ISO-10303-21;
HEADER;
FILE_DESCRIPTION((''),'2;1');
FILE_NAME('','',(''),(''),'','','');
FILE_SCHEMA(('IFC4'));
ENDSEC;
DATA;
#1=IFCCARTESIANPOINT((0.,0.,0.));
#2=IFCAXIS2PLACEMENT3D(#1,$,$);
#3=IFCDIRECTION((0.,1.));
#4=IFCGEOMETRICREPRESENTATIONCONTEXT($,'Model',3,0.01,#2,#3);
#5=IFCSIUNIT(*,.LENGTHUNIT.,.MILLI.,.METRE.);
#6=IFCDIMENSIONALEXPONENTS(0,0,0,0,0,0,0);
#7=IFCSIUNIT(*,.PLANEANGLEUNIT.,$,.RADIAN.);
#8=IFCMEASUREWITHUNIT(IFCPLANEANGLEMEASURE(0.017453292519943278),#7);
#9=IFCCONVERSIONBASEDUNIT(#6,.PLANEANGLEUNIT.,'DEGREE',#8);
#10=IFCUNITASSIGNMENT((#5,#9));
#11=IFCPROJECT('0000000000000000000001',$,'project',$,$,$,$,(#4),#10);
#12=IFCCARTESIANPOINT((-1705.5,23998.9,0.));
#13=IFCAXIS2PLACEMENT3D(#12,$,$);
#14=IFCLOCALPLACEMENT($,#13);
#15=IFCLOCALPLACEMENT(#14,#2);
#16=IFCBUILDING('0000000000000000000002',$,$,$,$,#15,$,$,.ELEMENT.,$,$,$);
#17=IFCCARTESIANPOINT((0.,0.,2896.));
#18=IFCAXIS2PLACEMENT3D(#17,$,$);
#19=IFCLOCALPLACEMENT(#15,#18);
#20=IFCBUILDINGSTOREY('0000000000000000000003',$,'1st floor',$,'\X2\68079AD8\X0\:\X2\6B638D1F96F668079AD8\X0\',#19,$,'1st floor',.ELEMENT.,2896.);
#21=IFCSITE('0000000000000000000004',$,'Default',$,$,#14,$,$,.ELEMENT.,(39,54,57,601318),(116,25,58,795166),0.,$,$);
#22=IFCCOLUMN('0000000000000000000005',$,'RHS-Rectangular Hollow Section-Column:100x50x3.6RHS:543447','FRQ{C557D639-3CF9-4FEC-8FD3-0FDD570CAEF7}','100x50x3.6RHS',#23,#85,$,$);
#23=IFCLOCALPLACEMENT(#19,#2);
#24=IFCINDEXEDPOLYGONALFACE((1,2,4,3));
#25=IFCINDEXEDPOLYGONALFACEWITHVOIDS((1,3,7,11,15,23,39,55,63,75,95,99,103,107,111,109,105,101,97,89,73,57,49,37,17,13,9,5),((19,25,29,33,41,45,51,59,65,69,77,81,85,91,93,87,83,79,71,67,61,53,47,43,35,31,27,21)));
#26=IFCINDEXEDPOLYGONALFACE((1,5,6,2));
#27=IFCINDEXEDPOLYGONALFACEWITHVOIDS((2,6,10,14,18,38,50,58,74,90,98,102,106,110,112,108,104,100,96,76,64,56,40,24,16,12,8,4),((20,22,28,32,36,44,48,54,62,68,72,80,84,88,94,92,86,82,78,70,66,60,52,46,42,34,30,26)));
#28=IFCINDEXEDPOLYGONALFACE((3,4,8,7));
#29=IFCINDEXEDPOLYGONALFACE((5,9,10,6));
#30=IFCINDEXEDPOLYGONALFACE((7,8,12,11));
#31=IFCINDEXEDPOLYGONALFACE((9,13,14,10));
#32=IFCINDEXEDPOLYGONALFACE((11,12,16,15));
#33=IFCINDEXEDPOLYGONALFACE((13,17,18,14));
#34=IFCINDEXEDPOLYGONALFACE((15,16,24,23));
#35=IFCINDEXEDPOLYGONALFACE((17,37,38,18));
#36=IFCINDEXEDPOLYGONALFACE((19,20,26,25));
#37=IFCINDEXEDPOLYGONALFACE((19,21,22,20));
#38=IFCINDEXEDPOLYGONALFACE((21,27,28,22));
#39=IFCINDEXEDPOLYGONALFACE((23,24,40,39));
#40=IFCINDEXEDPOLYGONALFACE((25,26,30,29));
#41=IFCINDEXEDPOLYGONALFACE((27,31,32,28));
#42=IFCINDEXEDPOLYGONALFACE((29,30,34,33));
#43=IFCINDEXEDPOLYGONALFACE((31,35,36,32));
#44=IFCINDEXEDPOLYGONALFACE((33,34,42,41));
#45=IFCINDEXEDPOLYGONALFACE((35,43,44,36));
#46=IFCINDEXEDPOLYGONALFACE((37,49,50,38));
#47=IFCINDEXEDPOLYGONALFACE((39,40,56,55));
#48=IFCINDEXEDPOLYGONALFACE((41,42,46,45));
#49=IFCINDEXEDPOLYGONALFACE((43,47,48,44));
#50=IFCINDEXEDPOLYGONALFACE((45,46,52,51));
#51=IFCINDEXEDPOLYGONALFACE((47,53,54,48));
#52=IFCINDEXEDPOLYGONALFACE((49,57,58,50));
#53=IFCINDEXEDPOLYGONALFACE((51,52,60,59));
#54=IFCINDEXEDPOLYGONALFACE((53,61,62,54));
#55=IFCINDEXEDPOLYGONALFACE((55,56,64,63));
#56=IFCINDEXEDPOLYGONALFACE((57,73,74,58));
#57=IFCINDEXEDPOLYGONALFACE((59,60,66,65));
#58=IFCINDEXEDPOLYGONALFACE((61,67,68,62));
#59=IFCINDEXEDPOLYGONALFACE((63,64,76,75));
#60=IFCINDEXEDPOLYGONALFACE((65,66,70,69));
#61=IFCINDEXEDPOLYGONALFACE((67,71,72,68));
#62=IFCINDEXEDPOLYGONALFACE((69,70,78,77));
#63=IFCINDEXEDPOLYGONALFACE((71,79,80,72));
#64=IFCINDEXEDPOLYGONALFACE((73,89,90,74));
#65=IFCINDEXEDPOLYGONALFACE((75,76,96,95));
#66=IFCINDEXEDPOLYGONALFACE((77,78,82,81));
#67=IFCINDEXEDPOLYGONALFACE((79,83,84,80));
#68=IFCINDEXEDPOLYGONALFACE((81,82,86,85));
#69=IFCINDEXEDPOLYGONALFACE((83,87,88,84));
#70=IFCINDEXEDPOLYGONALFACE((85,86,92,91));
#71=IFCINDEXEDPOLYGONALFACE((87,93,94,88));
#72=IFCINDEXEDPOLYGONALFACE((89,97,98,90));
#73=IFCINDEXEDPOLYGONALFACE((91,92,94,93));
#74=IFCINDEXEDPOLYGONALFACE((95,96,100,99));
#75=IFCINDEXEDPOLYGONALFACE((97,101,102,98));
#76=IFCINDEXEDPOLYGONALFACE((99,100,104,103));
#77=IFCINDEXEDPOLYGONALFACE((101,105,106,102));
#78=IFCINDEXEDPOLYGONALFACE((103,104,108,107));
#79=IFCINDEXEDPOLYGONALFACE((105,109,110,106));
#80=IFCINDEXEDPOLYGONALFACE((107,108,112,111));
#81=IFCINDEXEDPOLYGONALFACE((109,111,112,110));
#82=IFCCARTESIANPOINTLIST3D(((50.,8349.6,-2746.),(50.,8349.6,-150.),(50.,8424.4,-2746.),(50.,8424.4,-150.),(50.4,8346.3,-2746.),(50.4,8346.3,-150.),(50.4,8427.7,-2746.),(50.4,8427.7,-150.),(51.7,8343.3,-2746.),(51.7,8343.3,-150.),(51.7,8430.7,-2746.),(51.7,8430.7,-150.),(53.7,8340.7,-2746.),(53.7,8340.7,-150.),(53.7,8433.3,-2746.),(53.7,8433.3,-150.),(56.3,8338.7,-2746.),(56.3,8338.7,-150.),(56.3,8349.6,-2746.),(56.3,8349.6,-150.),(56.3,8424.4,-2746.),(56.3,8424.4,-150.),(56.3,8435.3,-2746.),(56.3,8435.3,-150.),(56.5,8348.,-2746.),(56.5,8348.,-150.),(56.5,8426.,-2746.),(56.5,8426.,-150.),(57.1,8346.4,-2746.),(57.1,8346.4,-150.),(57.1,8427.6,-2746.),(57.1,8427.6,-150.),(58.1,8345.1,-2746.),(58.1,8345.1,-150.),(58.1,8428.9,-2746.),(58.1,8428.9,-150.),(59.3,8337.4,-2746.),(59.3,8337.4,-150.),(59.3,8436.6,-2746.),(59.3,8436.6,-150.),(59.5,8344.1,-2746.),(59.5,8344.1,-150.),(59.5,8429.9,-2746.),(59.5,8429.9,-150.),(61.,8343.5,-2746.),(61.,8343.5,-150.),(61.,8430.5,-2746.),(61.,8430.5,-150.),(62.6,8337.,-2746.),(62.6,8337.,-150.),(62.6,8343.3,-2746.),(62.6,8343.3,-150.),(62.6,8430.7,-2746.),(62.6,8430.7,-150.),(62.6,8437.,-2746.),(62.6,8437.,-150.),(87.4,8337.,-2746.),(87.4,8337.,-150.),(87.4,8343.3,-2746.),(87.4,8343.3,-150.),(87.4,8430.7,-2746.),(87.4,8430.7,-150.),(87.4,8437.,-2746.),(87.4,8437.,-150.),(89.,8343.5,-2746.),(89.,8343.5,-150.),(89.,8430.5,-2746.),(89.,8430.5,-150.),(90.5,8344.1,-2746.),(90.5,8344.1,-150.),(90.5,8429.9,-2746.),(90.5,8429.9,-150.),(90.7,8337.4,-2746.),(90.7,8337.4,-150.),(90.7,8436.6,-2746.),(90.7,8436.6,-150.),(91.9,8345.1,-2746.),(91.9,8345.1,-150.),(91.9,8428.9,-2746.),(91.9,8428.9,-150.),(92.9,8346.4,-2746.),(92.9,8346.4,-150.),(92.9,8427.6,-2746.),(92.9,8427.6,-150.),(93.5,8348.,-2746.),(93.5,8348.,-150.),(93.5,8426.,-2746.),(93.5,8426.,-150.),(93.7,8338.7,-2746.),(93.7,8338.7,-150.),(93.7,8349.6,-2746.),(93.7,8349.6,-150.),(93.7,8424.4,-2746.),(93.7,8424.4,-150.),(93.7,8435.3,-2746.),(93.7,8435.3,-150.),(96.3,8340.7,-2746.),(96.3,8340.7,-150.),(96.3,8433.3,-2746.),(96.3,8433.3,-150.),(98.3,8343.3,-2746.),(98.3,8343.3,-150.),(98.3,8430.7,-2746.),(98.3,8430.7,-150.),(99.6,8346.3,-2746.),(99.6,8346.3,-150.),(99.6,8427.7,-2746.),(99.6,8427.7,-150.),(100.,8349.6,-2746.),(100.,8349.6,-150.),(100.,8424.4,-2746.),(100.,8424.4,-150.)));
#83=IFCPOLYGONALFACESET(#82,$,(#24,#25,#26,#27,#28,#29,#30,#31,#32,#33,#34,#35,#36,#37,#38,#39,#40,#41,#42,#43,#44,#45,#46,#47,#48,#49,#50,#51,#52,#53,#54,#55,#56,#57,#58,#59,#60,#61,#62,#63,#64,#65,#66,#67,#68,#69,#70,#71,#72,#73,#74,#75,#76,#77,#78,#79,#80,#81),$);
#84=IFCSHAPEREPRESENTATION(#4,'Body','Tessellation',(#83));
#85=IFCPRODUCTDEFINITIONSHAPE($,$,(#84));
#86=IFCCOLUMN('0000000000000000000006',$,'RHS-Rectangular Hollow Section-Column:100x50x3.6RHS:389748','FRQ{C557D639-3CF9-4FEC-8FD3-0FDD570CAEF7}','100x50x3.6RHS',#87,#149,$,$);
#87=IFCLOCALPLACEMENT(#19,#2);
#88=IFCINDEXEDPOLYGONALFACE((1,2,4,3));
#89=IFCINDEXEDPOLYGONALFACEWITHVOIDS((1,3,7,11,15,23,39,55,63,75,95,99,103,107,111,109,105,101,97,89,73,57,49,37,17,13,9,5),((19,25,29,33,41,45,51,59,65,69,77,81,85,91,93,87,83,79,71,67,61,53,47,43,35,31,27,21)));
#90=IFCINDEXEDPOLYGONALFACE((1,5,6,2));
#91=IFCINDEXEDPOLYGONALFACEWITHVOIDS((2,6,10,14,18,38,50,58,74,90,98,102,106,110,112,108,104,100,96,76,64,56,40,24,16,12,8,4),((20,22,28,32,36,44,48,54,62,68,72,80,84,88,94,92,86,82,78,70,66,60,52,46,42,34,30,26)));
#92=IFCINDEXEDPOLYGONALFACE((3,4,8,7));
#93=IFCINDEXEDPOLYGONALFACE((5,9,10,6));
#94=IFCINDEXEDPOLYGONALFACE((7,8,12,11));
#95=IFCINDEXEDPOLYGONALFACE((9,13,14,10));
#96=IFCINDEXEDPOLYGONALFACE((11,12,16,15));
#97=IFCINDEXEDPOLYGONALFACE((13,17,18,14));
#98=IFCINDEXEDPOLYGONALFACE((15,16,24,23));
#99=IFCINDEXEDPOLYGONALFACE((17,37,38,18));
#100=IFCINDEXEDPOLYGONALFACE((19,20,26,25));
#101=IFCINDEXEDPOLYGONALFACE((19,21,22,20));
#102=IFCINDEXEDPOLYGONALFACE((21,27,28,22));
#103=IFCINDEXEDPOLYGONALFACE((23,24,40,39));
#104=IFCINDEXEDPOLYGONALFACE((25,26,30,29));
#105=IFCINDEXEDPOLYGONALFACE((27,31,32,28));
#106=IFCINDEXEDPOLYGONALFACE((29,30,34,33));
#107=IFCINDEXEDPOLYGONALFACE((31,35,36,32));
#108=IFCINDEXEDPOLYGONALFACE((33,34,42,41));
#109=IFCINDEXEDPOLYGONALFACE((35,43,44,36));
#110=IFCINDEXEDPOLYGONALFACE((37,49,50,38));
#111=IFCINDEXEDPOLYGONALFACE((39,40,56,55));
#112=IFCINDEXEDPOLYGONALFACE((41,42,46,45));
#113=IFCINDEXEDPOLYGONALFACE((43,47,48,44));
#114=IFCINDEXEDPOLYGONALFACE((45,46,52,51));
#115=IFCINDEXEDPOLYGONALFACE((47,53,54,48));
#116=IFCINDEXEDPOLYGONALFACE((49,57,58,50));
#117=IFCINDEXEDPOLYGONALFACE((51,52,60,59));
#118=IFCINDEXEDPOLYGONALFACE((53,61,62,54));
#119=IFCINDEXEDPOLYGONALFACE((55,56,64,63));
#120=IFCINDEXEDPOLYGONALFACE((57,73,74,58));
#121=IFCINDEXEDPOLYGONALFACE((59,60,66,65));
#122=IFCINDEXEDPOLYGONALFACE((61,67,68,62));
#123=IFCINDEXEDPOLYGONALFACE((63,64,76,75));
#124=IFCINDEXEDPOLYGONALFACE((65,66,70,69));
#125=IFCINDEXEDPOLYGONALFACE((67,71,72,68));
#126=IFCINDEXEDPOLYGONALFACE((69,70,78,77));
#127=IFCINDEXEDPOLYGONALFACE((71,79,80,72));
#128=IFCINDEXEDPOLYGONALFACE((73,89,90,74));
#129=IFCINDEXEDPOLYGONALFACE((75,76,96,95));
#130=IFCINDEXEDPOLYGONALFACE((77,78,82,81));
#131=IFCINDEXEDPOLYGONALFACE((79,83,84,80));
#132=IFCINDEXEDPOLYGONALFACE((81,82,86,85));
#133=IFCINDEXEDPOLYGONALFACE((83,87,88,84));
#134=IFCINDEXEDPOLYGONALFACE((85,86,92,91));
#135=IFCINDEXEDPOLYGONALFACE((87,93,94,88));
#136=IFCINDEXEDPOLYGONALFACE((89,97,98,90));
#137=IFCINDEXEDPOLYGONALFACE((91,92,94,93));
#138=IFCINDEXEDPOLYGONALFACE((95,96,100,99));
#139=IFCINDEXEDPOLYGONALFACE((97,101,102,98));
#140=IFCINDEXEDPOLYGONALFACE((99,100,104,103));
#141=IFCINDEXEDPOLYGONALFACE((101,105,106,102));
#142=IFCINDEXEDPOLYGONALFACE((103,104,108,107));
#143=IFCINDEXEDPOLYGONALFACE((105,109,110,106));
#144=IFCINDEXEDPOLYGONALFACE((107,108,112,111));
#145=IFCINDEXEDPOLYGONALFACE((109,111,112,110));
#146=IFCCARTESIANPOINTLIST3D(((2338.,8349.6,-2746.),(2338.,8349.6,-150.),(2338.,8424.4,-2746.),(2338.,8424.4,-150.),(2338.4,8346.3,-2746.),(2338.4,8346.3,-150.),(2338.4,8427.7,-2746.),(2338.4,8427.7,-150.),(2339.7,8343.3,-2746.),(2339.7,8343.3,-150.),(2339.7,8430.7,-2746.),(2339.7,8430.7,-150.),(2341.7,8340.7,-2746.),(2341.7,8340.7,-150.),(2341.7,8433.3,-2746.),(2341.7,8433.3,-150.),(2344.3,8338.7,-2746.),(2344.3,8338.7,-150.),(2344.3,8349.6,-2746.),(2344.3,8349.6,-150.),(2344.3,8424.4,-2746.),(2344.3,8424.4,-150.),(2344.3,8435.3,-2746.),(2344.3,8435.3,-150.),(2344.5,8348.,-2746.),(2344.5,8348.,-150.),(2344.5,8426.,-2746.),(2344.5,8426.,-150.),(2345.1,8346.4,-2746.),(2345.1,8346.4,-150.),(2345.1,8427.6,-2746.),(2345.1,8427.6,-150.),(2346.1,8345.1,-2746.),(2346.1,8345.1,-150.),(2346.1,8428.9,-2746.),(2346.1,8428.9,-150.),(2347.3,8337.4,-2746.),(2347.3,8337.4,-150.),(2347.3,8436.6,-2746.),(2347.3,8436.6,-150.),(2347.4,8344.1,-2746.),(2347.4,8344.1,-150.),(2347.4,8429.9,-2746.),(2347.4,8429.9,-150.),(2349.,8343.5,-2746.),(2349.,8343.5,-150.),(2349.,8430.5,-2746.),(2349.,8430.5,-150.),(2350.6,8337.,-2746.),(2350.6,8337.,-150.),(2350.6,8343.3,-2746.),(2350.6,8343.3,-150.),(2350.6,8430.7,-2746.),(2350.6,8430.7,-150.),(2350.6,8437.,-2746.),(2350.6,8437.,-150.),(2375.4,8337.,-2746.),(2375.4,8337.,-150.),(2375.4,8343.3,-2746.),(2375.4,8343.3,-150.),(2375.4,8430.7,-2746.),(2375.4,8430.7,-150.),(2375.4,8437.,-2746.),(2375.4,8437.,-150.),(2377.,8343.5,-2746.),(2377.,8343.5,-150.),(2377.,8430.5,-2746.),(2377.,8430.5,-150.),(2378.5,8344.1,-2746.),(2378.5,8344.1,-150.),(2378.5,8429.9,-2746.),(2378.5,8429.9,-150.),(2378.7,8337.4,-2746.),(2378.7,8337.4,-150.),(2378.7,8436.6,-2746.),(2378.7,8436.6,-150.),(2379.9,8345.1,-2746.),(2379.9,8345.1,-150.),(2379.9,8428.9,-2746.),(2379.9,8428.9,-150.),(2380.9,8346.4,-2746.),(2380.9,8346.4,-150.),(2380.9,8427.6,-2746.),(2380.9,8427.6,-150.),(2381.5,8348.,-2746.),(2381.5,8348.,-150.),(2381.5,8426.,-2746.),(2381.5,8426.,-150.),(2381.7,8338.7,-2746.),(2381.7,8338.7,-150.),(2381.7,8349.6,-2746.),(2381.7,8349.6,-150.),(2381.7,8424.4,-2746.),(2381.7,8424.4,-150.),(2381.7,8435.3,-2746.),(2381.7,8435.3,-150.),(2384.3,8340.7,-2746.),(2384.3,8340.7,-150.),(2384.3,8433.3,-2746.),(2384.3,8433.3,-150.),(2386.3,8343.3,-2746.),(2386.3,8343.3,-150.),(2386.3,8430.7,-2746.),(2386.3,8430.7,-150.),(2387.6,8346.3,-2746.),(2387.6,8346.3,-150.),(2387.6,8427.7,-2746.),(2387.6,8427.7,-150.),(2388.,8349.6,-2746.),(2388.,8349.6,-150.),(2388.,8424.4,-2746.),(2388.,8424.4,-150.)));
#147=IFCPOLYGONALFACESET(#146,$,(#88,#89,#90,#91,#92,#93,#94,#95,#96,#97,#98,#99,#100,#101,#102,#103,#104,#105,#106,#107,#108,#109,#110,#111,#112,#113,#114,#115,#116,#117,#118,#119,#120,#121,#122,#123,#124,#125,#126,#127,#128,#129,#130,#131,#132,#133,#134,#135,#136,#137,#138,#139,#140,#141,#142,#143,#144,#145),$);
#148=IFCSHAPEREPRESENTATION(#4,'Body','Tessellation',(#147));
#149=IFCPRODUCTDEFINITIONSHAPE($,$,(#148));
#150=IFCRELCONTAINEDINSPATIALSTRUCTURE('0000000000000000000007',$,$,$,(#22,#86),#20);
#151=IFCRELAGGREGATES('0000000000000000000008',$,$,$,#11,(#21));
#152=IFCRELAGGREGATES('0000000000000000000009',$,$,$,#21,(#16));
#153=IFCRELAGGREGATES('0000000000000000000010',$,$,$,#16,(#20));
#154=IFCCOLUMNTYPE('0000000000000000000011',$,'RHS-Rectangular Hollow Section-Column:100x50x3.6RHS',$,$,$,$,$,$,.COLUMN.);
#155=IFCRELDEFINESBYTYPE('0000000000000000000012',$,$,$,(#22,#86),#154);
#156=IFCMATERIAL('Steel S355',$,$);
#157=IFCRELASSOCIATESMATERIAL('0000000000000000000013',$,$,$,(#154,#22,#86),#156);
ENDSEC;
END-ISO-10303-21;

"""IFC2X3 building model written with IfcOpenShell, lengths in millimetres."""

from ifc_helpers import new_model, entity, si_unit, converted_unit, direction, frame, origin, origin_2d, place, context, project, spatial, hollow_rectangle, extrude, clip, halfspace, material, type_object, element, save


model = new_model("IFC2X3")

# Units and contexts
model_context = context("Model", 3, precision=0.01, world=origin(), true_north=direction((0.0, 1.0)))
ifc_project = project(units=[si_unit("LENGTHUNIT", "METRE", prefix="MILLI"), converted_unit("PLANEANGLEUNIT", "DEGREE", entity("IfcPlaneAngleMeasure", 0.017453292519943278), si_unit("PLANEANGLEUNIT", "RADIAN"), dimensions=[0, 0, 0, 0, 0, 0, 0])], contexts=[model_context])

# Site, building, storey
site_placement = place(None, frame((-1705.5, 23998.9, 0.0)))
site = spatial("IfcSite", under=ifc_project, at=site_placement, Name="Default", CompositionType="ELEMENT", RefLatitude=(39, 54, 57, 601318), RefLongitude=(116, 25, 58, 795166), RefElevation=0.0)
building_placement = place(site_placement, origin())
building = spatial("IfcBuilding", under=site, at=building_placement, CompositionType="ELEMENT")
storey_placement = place(building_placement, frame((0.0, 0.0, 2896.0)))
storey = spatial("IfcBuildingStorey", under=building, at=storey_placement, Name="1st floor", ObjectType="标高:正负零标高", LongName="1st floor", CompositionType="ELEMENT", Elevation=2896.0)

# Columns
ifc_material_1 = material(Name="Steel S355")
column_type = type_object("IfcColumnType", Name="RHS-Rectangular Hollow Section-Column:100x50x3.6RHS", PredefinedType="COLUMN", material=ifc_material_1)
column_1_placement = place(storey_placement, frame((75.0, 8387.0, -150.0), z_axis=(0.0, 0.0, 1.0), x_axis=(-1.0, 0.0, 0.0)))
element("IfcColumn", 1, at=column_1_placement, inside=storey, type_object=column_type, material=ifc_material_1, Name="RHS-Rectangular Hollow Section-Column:100x50x3.6RHS:543447", Description="FRQ{C557D639-3CF9-4FEC-8FD3-0FDD570CAEF7}", ObjectType="100x50x3.6RHS", context=model_context, shape_type="Clipping", body=[
    clip(extrude(hollow_rectangle(XDim=50.0, YDim=100.0, WallThickness=6.3, InnerFilletRadius=6.3, OuterFilletRadius=12.6, at=origin_2d()), origin(), (0.0, 0.0, -1.0), 2651.9), halfspace(frame((75.0, 8387.0, -2596.0), z_axis=(0.0, 0.0, 1.0), x_axis=(-1.0, 0.0, 0.0)), True)),
])
column_2_placement = place(storey_placement, frame((2363.0, 8387.0, -150.0), z_axis=(0.0, 0.0, 1.0), x_axis=(-1.0, 0.0, 0.0)))
element("IfcColumn", 2, at=column_2_placement, inside=storey, type_object=column_type, material=ifc_material_1, Name="RHS-Rectangular Hollow Section-Column:100x50x3.6RHS:389748", Description="FRQ{C557D639-3CF9-4FEC-8FD3-0FDD570CAEF7}", ObjectType="100x50x3.6RHS", context=model_context, shape_type="Clipping", body=[
    clip(extrude(hollow_rectangle(XDim=50.0, YDim=100.0, WallThickness=6.3, InnerFilletRadius=6.3, OuterFilletRadius=12.6, at=origin_2d()), origin(), (0.0, 0.0, -1.0), 2651.9), halfspace(frame((2363.0, 8387.0, -2596.0), z_axis=(0.0, 0.0, 1.0), x_axis=(-1.0, 0.0, 0.0)), True)),
])

save(model, "model.ifc")
